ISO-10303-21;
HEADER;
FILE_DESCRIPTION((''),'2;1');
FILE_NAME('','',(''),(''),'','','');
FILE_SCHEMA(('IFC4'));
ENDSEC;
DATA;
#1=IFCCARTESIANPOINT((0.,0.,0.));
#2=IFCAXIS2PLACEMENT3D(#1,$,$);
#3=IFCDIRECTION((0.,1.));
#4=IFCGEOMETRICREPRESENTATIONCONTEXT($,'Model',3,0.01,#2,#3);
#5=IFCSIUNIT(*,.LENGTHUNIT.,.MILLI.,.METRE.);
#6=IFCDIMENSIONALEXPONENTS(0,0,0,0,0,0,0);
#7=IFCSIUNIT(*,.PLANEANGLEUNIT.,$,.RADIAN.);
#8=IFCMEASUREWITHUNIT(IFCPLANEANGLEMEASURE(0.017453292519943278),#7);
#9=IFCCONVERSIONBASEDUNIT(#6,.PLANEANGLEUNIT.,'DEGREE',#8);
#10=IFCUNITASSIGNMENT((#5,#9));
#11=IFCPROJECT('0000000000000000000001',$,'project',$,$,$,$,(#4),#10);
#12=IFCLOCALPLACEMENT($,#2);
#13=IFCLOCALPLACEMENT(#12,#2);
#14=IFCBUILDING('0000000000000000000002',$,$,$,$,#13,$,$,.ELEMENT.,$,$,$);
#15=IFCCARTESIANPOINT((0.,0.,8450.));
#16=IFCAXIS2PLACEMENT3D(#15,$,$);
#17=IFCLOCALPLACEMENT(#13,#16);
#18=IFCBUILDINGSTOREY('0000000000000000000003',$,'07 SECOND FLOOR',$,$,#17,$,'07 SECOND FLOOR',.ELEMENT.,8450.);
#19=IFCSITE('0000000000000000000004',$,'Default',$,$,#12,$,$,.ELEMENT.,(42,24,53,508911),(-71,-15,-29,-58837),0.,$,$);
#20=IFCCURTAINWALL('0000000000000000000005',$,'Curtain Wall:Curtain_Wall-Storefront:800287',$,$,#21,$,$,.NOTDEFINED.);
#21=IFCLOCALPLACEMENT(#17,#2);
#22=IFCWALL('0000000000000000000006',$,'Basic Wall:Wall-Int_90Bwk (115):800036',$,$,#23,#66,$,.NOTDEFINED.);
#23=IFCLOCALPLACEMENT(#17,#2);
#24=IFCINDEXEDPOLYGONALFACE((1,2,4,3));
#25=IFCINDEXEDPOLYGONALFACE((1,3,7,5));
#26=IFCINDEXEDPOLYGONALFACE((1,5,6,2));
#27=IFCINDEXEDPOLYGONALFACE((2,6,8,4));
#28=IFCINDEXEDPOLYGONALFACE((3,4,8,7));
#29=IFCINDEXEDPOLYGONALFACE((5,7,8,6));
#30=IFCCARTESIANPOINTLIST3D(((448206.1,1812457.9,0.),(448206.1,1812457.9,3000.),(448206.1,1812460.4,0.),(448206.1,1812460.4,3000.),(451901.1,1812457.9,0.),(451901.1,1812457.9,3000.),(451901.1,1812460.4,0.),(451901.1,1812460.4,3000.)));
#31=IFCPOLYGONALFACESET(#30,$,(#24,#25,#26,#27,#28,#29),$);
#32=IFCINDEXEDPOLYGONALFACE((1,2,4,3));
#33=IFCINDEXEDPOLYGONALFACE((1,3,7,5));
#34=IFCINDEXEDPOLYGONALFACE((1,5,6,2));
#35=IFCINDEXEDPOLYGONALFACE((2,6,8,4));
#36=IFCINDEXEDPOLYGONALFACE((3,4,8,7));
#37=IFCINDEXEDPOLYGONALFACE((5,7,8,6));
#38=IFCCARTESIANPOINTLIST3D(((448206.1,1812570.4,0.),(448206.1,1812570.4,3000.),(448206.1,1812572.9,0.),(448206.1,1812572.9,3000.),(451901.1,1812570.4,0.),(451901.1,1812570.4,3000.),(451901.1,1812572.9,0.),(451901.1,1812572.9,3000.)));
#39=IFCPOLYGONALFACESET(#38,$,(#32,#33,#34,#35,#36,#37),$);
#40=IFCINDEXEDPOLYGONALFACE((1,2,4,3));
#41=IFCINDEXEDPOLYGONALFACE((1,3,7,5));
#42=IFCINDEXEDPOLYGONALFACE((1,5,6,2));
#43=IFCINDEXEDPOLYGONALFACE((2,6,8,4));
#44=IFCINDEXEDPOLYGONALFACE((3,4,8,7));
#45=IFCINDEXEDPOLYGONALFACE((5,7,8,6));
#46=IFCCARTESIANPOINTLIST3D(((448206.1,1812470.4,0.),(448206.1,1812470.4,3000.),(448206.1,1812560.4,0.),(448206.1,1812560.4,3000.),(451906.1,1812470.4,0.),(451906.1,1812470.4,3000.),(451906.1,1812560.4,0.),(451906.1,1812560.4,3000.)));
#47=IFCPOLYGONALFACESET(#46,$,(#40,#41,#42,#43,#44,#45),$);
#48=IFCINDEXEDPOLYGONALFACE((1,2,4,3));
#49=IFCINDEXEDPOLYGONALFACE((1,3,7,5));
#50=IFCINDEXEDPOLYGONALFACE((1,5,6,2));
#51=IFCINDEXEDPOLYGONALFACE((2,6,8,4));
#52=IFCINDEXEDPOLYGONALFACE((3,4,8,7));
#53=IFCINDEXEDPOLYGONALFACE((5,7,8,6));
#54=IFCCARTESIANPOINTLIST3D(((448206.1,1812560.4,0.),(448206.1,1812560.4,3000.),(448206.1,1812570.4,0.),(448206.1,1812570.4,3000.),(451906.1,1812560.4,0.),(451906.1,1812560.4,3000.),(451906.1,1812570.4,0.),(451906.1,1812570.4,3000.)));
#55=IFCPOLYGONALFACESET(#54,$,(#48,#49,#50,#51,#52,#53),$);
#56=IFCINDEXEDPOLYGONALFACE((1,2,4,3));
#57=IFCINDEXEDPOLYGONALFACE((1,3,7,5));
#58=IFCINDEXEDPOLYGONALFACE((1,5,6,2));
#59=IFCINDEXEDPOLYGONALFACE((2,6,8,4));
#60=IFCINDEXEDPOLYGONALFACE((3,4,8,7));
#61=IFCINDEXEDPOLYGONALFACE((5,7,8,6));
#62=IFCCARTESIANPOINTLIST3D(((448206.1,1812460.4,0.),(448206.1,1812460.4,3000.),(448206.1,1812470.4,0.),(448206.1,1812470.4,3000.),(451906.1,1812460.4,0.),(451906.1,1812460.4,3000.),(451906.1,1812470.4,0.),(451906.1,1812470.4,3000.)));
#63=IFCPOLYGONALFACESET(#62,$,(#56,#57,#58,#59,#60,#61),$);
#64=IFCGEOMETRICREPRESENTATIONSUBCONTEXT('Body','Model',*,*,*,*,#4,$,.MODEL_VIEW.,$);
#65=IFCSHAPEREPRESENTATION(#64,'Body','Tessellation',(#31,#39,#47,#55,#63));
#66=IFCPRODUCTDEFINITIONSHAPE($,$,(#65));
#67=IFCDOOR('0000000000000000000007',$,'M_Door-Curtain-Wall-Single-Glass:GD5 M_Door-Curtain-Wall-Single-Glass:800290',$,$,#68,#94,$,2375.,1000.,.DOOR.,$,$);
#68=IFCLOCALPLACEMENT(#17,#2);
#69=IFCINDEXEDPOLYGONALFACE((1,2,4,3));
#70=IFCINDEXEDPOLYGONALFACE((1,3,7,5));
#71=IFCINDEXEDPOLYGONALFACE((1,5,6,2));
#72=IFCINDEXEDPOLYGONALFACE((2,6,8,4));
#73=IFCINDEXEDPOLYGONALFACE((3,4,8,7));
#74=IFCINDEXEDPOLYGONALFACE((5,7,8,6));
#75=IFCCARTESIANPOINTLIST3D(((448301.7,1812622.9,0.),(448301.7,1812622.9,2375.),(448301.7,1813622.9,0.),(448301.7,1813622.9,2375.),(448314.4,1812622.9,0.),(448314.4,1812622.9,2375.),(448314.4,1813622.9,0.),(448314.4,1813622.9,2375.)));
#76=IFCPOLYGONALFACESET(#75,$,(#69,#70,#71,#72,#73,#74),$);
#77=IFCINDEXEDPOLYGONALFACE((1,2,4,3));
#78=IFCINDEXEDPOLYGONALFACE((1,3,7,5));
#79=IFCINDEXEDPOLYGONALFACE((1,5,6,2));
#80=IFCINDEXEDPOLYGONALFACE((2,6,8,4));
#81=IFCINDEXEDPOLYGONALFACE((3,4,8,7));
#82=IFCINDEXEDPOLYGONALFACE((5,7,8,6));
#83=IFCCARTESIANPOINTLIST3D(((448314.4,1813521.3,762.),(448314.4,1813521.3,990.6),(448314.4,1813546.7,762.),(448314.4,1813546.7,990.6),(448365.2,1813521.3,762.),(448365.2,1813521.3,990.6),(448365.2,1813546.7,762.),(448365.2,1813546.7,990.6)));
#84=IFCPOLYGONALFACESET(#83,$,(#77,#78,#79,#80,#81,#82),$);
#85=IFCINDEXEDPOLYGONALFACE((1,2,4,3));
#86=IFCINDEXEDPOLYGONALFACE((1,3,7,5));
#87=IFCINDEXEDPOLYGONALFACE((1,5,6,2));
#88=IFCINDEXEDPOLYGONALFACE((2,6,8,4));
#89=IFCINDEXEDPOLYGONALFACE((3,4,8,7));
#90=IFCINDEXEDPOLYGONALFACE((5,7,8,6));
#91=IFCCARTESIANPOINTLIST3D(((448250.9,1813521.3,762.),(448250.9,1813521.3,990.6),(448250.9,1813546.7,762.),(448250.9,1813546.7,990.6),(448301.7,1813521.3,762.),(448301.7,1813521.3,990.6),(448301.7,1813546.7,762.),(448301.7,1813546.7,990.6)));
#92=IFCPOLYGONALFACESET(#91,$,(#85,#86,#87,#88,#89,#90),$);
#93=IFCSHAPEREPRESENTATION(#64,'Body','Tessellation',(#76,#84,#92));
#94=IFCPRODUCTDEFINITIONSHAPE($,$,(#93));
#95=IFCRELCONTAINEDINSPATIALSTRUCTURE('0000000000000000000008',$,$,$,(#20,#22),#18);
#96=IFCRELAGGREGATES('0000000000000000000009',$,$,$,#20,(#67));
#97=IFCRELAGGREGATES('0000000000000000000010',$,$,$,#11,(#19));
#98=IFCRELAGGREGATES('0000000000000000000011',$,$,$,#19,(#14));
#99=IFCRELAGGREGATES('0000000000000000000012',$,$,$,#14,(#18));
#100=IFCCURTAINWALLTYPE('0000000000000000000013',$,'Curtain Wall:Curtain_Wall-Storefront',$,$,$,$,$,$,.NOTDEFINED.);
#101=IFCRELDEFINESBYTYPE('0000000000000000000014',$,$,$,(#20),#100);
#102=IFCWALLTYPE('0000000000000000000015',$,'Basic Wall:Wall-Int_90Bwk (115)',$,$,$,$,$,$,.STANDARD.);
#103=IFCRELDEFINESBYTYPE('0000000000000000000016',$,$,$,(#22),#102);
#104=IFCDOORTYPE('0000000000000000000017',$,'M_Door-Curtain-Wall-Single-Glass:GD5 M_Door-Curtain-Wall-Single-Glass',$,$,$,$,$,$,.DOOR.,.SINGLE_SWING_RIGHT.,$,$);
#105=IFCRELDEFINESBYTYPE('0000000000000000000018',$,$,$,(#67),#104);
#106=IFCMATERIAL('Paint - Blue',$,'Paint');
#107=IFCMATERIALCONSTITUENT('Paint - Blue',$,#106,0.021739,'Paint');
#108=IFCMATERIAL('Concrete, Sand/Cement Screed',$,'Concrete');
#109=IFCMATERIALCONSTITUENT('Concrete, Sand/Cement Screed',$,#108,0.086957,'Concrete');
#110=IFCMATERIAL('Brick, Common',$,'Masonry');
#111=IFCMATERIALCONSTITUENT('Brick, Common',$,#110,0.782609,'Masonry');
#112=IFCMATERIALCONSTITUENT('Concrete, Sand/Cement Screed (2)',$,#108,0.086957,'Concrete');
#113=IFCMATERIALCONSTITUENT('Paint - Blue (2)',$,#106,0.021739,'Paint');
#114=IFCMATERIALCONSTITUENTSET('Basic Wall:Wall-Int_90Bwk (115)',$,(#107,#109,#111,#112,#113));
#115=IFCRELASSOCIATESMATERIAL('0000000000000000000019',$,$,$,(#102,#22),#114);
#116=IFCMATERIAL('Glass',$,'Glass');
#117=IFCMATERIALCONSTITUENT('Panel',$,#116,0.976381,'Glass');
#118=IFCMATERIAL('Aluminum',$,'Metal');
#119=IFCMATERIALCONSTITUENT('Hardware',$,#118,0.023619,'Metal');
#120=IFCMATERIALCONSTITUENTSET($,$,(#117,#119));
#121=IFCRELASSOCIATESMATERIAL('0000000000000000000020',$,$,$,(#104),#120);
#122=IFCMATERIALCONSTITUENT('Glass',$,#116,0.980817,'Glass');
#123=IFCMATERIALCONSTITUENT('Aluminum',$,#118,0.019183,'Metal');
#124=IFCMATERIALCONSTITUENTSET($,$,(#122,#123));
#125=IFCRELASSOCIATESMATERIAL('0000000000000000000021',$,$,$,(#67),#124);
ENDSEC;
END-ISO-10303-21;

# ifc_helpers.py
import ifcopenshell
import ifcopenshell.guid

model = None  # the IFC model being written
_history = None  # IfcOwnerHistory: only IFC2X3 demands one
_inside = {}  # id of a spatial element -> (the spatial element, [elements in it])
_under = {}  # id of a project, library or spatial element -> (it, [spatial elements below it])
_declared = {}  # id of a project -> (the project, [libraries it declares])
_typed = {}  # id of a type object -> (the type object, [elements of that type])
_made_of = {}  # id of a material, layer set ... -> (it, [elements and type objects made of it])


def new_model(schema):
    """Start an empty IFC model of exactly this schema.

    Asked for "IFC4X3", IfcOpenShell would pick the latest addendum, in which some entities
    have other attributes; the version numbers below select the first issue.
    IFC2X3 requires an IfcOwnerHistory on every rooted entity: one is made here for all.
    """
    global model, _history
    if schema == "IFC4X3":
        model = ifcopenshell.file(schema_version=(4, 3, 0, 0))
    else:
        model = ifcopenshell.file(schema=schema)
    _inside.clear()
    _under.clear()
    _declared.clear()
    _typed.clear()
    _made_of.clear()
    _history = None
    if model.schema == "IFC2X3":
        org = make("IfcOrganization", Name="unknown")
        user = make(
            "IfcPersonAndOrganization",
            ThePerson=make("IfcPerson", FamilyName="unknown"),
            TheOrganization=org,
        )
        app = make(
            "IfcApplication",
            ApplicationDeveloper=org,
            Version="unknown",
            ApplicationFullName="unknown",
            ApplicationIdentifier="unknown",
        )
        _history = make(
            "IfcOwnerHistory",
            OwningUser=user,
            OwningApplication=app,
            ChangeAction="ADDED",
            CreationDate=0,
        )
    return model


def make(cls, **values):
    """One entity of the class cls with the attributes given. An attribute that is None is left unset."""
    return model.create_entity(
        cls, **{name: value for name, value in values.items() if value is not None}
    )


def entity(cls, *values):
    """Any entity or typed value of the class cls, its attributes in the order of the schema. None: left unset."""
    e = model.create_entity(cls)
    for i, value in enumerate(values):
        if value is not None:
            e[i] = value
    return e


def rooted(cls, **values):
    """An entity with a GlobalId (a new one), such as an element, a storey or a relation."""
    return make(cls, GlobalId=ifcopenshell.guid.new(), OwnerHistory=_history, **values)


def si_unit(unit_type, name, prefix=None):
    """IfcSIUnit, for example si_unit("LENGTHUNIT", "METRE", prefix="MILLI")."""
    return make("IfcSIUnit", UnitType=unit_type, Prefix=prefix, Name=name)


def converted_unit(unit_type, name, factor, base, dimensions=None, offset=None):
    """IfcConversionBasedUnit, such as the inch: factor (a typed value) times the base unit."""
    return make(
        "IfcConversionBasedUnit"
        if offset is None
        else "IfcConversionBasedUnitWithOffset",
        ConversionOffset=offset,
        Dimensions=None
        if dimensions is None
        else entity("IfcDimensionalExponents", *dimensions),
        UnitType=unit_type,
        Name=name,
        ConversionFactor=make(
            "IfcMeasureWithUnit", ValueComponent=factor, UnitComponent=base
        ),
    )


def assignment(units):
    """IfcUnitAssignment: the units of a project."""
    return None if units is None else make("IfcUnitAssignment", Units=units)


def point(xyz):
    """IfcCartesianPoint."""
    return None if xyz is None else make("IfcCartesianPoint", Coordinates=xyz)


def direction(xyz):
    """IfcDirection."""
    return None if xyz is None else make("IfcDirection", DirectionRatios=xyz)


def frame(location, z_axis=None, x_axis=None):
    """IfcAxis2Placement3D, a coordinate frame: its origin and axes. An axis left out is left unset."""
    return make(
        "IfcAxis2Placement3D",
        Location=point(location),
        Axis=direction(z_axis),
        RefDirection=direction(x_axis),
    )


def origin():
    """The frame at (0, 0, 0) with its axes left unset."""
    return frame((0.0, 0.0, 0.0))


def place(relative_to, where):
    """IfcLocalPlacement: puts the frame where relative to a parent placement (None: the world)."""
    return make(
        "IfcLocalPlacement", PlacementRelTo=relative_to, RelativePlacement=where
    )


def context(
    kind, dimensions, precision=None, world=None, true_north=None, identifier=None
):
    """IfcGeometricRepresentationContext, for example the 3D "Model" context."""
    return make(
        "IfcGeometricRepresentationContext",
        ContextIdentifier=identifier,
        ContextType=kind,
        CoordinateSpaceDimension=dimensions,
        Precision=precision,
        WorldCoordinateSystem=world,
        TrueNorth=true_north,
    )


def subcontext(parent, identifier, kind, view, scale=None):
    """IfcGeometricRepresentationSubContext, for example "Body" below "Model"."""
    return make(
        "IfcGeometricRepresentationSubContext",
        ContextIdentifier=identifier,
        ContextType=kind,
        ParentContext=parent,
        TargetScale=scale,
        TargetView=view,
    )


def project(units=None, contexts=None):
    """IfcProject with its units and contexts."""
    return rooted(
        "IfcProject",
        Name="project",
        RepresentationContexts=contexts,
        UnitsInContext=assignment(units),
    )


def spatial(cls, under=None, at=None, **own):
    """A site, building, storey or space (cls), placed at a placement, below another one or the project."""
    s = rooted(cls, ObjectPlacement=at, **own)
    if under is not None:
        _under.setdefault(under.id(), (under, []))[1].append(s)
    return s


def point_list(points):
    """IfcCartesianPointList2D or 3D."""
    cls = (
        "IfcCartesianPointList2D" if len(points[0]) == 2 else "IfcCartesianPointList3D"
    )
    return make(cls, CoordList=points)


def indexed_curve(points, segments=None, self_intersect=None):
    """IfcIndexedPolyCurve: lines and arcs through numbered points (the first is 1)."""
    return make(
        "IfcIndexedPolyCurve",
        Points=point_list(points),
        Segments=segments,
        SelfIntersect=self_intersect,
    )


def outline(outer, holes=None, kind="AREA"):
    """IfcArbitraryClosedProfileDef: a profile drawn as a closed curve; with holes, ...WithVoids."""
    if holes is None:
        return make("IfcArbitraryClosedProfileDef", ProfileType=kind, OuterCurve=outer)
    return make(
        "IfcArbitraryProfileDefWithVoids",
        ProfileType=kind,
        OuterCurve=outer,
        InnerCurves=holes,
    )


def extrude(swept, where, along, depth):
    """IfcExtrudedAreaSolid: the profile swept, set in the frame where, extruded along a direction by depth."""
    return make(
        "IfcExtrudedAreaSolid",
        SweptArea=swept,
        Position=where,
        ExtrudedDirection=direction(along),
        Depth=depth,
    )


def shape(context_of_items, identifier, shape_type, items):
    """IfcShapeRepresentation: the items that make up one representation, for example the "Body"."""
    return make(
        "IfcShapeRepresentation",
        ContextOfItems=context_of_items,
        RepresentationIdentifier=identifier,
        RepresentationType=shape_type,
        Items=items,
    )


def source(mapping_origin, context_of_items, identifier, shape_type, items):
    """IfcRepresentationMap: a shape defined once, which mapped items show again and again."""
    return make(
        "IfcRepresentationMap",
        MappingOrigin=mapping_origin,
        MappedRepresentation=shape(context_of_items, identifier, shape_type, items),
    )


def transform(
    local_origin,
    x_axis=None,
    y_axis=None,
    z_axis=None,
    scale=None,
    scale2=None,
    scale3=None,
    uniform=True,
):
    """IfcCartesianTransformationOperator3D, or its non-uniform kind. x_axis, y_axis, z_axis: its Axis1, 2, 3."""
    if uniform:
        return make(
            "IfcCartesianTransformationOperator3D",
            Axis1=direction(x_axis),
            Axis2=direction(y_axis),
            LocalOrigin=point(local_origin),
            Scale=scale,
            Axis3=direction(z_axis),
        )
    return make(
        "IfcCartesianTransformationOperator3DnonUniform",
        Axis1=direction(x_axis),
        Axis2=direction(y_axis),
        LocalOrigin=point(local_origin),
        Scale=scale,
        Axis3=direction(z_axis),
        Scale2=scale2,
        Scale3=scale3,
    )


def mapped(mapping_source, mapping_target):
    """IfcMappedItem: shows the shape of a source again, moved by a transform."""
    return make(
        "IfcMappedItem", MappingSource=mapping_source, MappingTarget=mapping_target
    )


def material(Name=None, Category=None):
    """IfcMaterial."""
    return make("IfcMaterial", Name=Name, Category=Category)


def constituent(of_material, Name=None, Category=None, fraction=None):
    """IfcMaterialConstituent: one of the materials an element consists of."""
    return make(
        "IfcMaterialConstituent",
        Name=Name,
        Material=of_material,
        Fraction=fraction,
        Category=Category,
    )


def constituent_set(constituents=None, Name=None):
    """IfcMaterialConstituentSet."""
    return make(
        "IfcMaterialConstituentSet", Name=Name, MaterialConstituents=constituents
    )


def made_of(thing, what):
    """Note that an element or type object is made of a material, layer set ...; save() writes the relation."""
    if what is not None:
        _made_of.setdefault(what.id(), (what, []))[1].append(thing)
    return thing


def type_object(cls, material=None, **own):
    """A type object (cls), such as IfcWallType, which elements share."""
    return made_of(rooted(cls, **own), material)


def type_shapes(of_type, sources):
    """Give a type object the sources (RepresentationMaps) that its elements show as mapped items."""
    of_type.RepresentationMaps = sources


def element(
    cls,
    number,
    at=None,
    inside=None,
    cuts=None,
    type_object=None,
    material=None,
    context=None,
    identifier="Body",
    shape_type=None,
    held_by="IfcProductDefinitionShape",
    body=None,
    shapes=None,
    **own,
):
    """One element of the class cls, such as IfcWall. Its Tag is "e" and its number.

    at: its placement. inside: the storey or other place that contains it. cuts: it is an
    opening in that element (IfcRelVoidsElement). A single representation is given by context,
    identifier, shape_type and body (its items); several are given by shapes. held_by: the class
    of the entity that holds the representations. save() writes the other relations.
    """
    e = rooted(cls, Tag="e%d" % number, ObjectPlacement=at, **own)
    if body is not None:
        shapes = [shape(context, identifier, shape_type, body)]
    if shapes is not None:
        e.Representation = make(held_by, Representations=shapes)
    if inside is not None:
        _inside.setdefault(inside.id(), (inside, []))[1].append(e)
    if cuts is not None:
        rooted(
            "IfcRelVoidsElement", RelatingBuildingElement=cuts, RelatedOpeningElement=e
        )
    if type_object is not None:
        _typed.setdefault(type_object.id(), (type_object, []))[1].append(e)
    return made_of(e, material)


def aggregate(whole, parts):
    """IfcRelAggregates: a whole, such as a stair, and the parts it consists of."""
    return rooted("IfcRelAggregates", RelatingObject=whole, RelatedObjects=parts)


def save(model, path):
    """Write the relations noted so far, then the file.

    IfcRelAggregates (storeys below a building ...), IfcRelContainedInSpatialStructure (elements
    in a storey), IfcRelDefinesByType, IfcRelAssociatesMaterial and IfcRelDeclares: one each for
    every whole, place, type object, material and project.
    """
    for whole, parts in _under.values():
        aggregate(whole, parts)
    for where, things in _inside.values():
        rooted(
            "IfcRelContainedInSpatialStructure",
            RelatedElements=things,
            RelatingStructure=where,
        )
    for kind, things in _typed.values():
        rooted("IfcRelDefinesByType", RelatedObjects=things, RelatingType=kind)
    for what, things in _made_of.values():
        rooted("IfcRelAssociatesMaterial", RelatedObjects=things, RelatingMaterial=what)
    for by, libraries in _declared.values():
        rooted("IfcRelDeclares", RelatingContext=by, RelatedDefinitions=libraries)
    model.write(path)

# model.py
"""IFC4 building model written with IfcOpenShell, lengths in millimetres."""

from ifc_helpers import new_model, entity, si_unit, converted_unit, direction, frame, origin, place, context, subcontext, project, spatial, indexed_curve, outline, extrude, source, transform, mapped, material, constituent, constituent_set, type_object, type_shapes, element, aggregate, save


model = new_model("IFC4")

# Units and contexts
model_context = context("Model", 3, precision=0.01, world=origin(), true_north=direction((0.0, 1.0)))
body_context = subcontext(model_context, "Body", "Model", "MODEL_VIEW")
ifc_project = project(units=[si_unit("LENGTHUNIT", "METRE", prefix="MILLI"), converted_unit("PLANEANGLEUNIT", "DEGREE", entity("IfcPlaneAngleMeasure", 0.017453292519943278), si_unit("PLANEANGLEUNIT", "RADIAN"), dimensions=[0, 0, 0, 0, 0, 0, 0])], contexts=[model_context])

# Site, building, storey
site_placement = place(None, origin())
site = spatial("IfcSite", under=ifc_project, at=site_placement, Name="Default", CompositionType="ELEMENT", RefLatitude=(42, 24, 53, 508911), RefLongitude=(-71, -15, -29, -58837), RefElevation=0.0)
building_placement = place(site_placement, origin())
building = spatial("IfcBuilding", under=site, at=building_placement, CompositionType="ELEMENT")
storey_placement = place(building_placement, frame((0.0, 0.0, 8450.0)))
storey = spatial("IfcBuildingStorey", under=building, at=storey_placement, Name="07 SECOND FLOOR", LongName="07 SECOND FLOOR", CompositionType="ELEMENT", Elevation=8450.0)

# Shared definitions
curtain_wall_type = type_object("IfcCurtainWallType", Name="Curtain Wall:Curtain_Wall-Storefront", PredefinedType="NOTDEFINED")

# Curtain wall
curtain_wall_1_placement = place(storey_placement, frame((0.0, 0.0, -8450.0)))
curtain_wall_1 = element("IfcCurtainWall", 1, at=curtain_wall_1_placement, inside=storey, type_object=curtain_wall_type, Name="Curtain Wall:Curtain_Wall-Storefront:800287", PredefinedType="NOTDEFINED")

# Shared definitions
ifc_material_1 = material(Name="Glass", Category="Glass")

# Wall
ifc_material_2 = material(Name="Paint - Blue", Category="Paint")
ifc_constituent_1 = constituent(ifc_material_2, Name="Paint - Blue", Category="Paint", fraction=0.021739)
ifc_material_3 = material(Name="Concrete, Sand/Cement Screed", Category="Concrete")
ifc_constituent_2 = constituent(ifc_material_3, Name="Concrete, Sand/Cement Screed", Category="Concrete", fraction=0.086957)
ifc_material_4 = material(Name="Brick, Common", Category="Masonry")
ifc_constituent_3 = constituent(ifc_material_4, Name="Brick, Common", Category="Masonry", fraction=0.782609)
ifc_constituent_4 = constituent(ifc_material_3, Name="Concrete, Sand/Cement Screed (2)", Category="Concrete", fraction=0.086957)
ifc_constituent_5 = constituent(ifc_material_2, Name="Paint - Blue (2)", Category="Paint", fraction=0.021739)
ifc_constituent_set_1 = constituent_set(constituents=[ifc_constituent_1, ifc_constituent_2, ifc_constituent_3, ifc_constituent_4, ifc_constituent_5], Name="Basic Wall:Wall-Int_90Bwk (115)")
wall_type_1 = type_object("IfcWallType", Name="Basic Wall:Wall-Int_90Bwk (115)", PredefinedType="STANDARD", material=ifc_constituent_set_1)
wall_1_placement = place(storey_placement, frame((448206.1, 1812515.4, 0.0)))
element("IfcWall", 2, at=wall_1_placement, inside=storey, type_object=wall_type_1, material=ifc_constituent_set_1, Name="Basic Wall:Wall-Int_90Bwk (115):800036", PredefinedType="NOTDEFINED", context=body_context, shape_type="SweptSolid", body=[
    extrude(outline(indexed_curve([(-1.2, -1847.5), (1.3, -1847.5), (1.3, 1847.5), (-1.2, 1847.5), (-1.2, -1847.5)], self_intersect=False)), frame((1847.5, -56.3, 0.0), z_axis=(0.0, 0.0, 1.0), x_axis=(0.0, 1.0, 0.0)), (0.0, 0.0, 1.0), 3000.0),
    extrude(outline(indexed_curve([(-1.3, -1847.5), (1.3, -1847.5), (1.3, 1847.5), (-1.3, 1847.5), (-1.3, -1847.5)], self_intersect=False)), frame((1847.5, 56.3, 0.0), z_axis=(0.0, 0.0, 1.0), x_axis=(0.0, -1.0, 0.0)), (0.0, 0.0, 1.0), 3000.0),
    extrude(outline(indexed_curve([(-1850.0, -45.0), (1850.0, -45.0), (1850.0, 45.0), (-1850.0, 45.0), (-1850.0, -45.0)], self_intersect=False)), frame((1850.0, 0.0, 0.0)), (0.0, 0.0, 1.0), 3000.0),
    extrude(outline(indexed_curve([(-1850.0, -5.0), (1850.0, -5.0), (1850.0, 5.0), (-1850.0, 5.0), (-1850.0, -5.0)], self_intersect=False)), frame((1850.0, 50.0, 0.0)), (0.0, 0.0, 1.0), 3000.0),
    extrude(outline(indexed_curve([(-1850.0, -5.0), (1850.0, -5.0), (1850.0, 5.0), (-1850.0, 5.0), (-1850.0, -5.0)], self_intersect=False)), frame((1850.0, -50.0, 0.0)), (0.0, 0.0, 1.0), 3000.0),
])

# Door
ifc_constituent_6 = constituent(ifc_material_1, Name="Glass", Category="Glass", fraction=0.980817)
ifc_material_5 = material(Name="Aluminum", Category="Metal")
ifc_constituent_7 = constituent(ifc_material_5, Name="Aluminum", Category="Metal", fraction=0.019183)
ifc_constituent_set_2 = constituent_set(constituents=[ifc_constituent_6, ifc_constituent_7])
ifc_constituent_8 = constituent(ifc_material_1, Name="Panel", Category="Glass", fraction=0.976381)
ifc_constituent_9 = constituent(ifc_material_5, Name="Hardware", Category="Metal", fraction=0.023619)
ifc_constituent_set_3 = constituent_set(constituents=[ifc_constituent_8, ifc_constituent_9])
door_type = type_object("IfcDoorType", Name="M_Door-Curtain-Wall-Single-Glass:GD5 M_Door-Curtain-Wall-Single-Glass", OperationType="SINGLE_SWING_RIGHT", PredefinedType="DOOR", material=ifc_constituent_set_3)
shared_shape_1 = source(origin(), body_context, "Body", "SweptSolid", [
    extrude(outline(indexed_curve([(-500.0, -6.4), (500.0, -6.4), (500.0, 6.4), (-500.0, 6.4), (-500.0, -6.4)], self_intersect=False)), frame((0.0, 44.5, 0.0), z_axis=(0.0, 0.0, 1.0), x_axis=(-1.0, 0.0, 0.0)), (0.0, 0.0, 1.0), 2375.0),
    extrude(outline(indexed_curve([(-25.4, -12.7), (25.4, -12.7), (25.4, 12.7), (-25.4, 12.7), (-25.4, -12.7)], self_intersect=False)), frame((-411.1, 76.2, 762.0), z_axis=(0.0, 0.0, 1.0), x_axis=(0.0, -1.0, 0.0)), (0.0, 0.0, 1.0), 228.6),
    extrude(outline(indexed_curve([(-25.4, -12.7), (25.4, -12.7), (25.4, 12.7), (-25.4, 12.7), (-25.4, -12.7)], self_intersect=False)), frame((-411.1, 12.7, 762.0), z_axis=(0.0, 0.0, 1.0), x_axis=(0.0, 1.0, 0.0)), (0.0, 0.0, 1.0), 228.6),
])
type_shapes(door_type, [shared_shape_1])
door_placement = place(curtain_wall_1_placement, frame((448263.6, 1813122.9, 8450.0), z_axis=(0.0, 0.0, 1.0), x_axis=(0.0, -1.0, 0.0)))
door = element("IfcDoor", 3, at=door_placement, type_object=door_type, material=ifc_constituent_set_2, Name="M_Door-Curtain-Wall-Single-Glass:GD5 M_Door-Curtain-Wall-Single-Glass:800290", OverallHeight=2375.0, OverallWidth=1000.0, PredefinedType="DOOR", context=body_context, shape_type="MappedRepresentation", body=[
    mapped(shared_shape_1, transform((0.0, 0.0, 0.0), scale=1.0)),
])
aggregate(curtain_wall_1, [door])

save(model, "model.ifc")
